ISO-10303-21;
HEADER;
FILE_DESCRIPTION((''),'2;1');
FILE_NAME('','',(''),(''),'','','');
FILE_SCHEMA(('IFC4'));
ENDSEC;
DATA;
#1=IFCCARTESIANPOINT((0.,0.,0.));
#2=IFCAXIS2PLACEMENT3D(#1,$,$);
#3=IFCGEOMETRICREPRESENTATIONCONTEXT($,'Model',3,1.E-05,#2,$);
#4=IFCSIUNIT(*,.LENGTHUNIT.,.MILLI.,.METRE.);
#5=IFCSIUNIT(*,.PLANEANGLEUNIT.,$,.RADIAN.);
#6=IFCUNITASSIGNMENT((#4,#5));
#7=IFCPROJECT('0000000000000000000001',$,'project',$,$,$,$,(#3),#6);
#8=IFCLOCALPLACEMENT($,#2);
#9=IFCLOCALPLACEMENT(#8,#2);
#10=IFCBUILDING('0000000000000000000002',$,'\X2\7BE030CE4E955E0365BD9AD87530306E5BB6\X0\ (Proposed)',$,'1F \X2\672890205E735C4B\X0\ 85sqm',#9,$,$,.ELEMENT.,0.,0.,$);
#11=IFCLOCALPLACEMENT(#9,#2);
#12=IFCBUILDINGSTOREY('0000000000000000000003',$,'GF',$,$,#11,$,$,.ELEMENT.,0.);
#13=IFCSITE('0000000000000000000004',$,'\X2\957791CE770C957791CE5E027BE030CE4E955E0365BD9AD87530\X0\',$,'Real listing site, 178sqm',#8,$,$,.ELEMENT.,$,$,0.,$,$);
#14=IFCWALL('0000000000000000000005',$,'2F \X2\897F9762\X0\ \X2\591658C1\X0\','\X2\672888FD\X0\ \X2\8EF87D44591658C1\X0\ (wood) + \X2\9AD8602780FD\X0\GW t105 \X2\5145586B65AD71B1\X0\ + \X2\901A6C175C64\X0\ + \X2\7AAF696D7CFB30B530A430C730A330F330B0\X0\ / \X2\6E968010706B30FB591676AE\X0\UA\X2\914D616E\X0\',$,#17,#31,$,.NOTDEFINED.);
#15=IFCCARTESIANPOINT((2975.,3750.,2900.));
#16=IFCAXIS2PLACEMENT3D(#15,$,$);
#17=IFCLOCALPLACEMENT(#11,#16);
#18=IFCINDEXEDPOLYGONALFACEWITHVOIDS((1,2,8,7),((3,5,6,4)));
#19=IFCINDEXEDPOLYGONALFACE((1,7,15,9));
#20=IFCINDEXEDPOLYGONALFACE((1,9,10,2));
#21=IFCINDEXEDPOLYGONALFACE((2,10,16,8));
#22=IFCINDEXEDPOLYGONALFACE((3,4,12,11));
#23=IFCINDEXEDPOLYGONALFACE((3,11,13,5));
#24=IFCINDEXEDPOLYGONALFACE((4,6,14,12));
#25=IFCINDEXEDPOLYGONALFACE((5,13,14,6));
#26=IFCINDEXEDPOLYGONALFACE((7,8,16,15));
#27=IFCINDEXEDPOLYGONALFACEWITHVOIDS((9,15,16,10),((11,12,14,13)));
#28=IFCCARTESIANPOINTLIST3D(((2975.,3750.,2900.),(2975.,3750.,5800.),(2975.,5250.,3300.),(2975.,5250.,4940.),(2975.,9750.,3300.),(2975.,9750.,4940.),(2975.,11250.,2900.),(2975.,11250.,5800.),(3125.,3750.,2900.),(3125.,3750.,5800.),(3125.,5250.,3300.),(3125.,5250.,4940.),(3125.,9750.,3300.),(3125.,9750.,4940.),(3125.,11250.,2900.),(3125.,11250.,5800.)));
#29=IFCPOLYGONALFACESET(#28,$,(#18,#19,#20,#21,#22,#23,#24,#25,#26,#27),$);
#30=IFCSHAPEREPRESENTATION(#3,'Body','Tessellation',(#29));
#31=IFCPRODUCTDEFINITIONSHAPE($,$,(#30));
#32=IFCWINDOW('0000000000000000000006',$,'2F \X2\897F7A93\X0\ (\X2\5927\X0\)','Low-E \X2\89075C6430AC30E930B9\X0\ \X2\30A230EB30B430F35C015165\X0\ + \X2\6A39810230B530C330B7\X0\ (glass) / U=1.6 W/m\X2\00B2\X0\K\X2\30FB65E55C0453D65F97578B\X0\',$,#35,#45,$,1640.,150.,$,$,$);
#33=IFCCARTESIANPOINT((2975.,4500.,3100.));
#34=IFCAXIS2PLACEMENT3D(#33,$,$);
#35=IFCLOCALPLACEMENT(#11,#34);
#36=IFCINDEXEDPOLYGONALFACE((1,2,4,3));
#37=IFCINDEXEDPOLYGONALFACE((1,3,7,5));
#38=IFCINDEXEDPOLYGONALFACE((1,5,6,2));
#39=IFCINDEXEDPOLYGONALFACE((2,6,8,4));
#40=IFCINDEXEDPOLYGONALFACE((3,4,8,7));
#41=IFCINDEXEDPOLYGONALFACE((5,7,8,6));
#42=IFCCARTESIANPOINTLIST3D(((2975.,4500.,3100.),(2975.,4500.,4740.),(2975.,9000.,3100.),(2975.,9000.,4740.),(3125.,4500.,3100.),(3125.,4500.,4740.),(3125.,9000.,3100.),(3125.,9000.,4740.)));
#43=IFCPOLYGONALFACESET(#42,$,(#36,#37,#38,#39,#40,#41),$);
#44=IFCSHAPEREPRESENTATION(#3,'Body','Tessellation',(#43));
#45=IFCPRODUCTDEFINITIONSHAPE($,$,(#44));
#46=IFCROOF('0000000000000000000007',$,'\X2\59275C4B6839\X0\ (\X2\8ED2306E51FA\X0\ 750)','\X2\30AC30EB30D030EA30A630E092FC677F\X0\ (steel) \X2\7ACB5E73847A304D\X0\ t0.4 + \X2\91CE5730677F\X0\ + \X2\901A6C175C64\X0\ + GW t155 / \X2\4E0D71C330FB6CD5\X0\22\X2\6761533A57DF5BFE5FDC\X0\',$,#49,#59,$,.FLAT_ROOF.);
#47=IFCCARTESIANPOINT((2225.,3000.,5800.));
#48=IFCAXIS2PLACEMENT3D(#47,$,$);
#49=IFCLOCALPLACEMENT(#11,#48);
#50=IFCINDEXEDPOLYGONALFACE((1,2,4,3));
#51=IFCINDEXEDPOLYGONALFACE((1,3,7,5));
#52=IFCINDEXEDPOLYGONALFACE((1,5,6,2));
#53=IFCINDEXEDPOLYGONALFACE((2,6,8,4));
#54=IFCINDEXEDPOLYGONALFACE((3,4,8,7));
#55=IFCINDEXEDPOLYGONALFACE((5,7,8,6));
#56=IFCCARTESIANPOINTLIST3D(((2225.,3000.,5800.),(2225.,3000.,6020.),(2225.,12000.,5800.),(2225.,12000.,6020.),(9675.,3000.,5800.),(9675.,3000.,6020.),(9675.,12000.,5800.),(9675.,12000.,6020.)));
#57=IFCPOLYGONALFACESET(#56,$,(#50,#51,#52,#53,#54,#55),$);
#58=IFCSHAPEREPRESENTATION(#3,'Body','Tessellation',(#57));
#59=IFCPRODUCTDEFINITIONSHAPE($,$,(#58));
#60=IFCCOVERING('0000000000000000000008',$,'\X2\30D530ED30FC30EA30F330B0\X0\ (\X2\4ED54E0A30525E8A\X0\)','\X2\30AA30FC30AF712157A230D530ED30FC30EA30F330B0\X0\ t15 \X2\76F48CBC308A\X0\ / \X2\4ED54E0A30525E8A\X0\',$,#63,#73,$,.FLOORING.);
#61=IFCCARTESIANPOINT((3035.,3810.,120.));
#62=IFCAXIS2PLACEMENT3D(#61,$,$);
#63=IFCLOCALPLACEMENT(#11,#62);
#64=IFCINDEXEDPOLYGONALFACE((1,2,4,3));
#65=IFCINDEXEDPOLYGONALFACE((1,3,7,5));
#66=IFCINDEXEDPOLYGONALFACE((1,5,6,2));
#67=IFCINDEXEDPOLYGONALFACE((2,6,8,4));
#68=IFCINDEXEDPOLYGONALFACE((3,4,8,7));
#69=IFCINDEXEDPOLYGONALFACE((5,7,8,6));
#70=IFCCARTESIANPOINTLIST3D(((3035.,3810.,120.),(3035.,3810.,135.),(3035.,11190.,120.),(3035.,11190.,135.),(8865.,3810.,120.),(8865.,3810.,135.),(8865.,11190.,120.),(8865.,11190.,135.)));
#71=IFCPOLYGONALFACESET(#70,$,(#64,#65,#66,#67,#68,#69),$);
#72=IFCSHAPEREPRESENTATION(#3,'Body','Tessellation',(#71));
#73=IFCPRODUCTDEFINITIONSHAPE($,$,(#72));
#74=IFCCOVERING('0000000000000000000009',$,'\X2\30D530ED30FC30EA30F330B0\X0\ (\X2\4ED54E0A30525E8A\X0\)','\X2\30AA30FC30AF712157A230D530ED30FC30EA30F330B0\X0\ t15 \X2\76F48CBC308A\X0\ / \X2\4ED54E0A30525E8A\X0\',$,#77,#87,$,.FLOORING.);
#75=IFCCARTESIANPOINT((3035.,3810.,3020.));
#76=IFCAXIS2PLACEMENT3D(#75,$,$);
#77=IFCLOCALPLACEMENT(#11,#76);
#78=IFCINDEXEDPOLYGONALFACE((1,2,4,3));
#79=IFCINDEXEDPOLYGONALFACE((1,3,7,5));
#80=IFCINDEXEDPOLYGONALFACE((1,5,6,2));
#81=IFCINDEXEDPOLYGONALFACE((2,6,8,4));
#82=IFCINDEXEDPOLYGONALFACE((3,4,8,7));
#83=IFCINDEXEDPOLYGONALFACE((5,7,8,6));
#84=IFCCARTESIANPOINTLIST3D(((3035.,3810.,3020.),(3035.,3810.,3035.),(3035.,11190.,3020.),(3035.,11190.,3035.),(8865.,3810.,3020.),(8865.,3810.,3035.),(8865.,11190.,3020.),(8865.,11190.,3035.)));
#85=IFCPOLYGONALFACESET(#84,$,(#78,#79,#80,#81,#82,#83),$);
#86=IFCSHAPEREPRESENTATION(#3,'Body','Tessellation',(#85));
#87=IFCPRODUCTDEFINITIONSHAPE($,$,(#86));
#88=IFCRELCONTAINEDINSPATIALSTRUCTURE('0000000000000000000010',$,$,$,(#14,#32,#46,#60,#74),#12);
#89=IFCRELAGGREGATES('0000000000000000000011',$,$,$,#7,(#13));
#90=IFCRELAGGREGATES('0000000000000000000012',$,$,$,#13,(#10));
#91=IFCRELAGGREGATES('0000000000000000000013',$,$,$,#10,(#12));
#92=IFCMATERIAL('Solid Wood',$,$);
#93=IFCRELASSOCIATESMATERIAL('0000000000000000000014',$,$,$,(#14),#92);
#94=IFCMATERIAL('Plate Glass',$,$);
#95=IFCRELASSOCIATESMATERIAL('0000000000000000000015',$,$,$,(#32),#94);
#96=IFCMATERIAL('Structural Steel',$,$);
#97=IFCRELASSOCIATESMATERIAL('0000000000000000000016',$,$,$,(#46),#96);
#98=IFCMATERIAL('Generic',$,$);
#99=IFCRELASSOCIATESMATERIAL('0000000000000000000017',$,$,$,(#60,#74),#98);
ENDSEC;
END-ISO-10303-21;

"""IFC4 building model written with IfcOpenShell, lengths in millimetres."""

from ifc_helpers import new_model, si_unit, frame, frame_2d, origin, place, context, project, spatial, rectangle, extrude, material, element, fill, save


model = new_model("IFC4")

# Units and contexts
model_context = context("Model", 3, precision=1e-05, world=origin())
ifc_project = project(units=[si_unit("LENGTHUNIT", "METRE", prefix="MILLI"), si_unit("PLANEANGLEUNIT", "RADIAN")], contexts=[model_context])

# Site, building, storey
site_placement = place(None, origin())
site = spatial("IfcSite", under=ifc_project, at=site_placement, Name="長野県長野市篠ノ井布施高田", ObjectType="Real listing site, 178sqm", CompositionType="ELEMENT", RefElevation=0.0)
building_placement = place(site_placement, origin())
building = spatial("IfcBuilding", under=site, at=building_placement, Name="篠ノ井布施高田の家 (Proposed)", ObjectType="1F 木造平屋 85sqm", CompositionType="ELEMENT", ElevationOfRefHeight=0.0, ElevationOfTerrain=0.0)
storey_placement = place(building_placement, origin())
storey = spatial("IfcBuildingStorey", under=building, at=storey_placement, Name="GF", CompositionType="ELEMENT", Elevation=0.0)

# Shared definitions
ifc_material_1 = material(Name="Solid Wood")
ifc_material_2 = material(Name="Generic")

# Shared definitions
ifc_material_3 = material(Name="Plate Glass")

# Wall, opening, window
wall_1_placement = place(storey_placement, frame((2975.0, 3750.0, 2900.0)))
wall_1 = element("IfcWall", 1, at=wall_1_placement, inside=storey, material=ifc_material_1, Name="2F 西面 外壁", Description="木製 軸組外壁 (wood) + 高性能GW t105 充填断熱 + 通気層 + 窯業系サイディング / 準耐火・外皮UA配慮", PredefinedType="NOTDEFINED", context=model_context, shape_type="SweptSolid", body=[
    extrude(rectangle(XDim=150.0, YDim=7500.0, at=frame_2d((75.0, 3750.0))), frame((2975.0, 3750.0, 2900.0)), (0.0, 0.0, 1.0), 2900.0),
])
opening_1_placement = place(storey_placement, frame((2975.0, 4500.0, 3100.0)))
opening_1 = element("IfcOpeningElement", 2, at=opening_1_placement, cuts=wall_1, PredefinedType="NOTDEFINED", context=model_context, shape_type="SweptSolid", body=[
    extrude(rectangle(XDim=150.0, YDim=4500.0, at=frame_2d((75.0, 2250.0))), frame((2975.0, 4500.0, 3100.0)), (0.0, 0.0, 1.0), 1640.0),
])
window_1_placement = place(storey_placement, frame((2975.0, 4500.0, 3100.0)))
window_1 = element("IfcWindow", 3, at=window_1_placement, inside=storey, material=ifc_material_3, Name="2F 西窓 (大)", Description="Low-E 複層ガラス アルゴン封入 + 樹脂サッシ (glass) / U=1.6 W/m²K・日射取得型", OverallHeight=1640.0, OverallWidth=150.0, context=model_context, shape_type="SweptSolid", body=[
    extrude(rectangle(XDim=150.0, YDim=4500.0, at=frame_2d((75.0, 2250.0))), frame((2975.0, 4500.0, 3100.0)), (0.0, 0.0, 1.0), 1640.0),
])
fill(opening_1, window_1)

# Roof
ifc_material_4 = material(Name="Structural Steel")
roof_placement = place(storey_placement, frame((2225.0, 3000.0, 5800.0)))
element("IfcRoof", 4, at=roof_placement, inside=storey, material=ifc_material_4, Name="大屋根 (軒の出 750)", Description="ガルバリウム鋼板 (steel) 立平葺き t0.4 + 野地板 + 通気層 + GW t155 / 不燃・法22条区域対応", PredefinedType="FLAT_ROOF", context=model_context, shape_type="SweptSolid", body=[
    extrude(rectangle(XDim=7450.0, YDim=9000.0, at=frame_2d((3725.0, 4500.0))), frame((2225.0, 3000.0, 5800.0)), (0.0, 0.0, 1.0), 220.0),
])

# Coverings
covering_1_placement = place(storey_placement, frame((3035.0, 3810.0, 120.0)))
element("IfcCovering", 5, at=covering_1_placement, inside=storey, material=ifc_material_2, Name="フローリング (仕上げ床)", Description="オーク無垢フローリング t15 直貼り / 仕上げ床", PredefinedType="FLOORING", context=model_context, shape_type="SweptSolid", body=[
    extrude(rectangle(XDim=5830.0, YDim=7380.0, at=frame_2d((2915.0, 3690.0))), frame((3035.0, 3810.0, 120.0)), (0.0, 0.0, 1.0), 15.0),
])
covering_2_placement = place(storey_placement, frame((3035.0, 3810.0, 3020.0)))
element("IfcCovering", 6, at=covering_2_placement, inside=storey, material=ifc_material_2, Name="フローリング (仕上げ床)", Description="オーク無垢フローリング t15 直貼り / 仕上げ床", PredefinedType="FLOORING", context=model_context, shape_type="SweptSolid", body=[
    extrude(rectangle(XDim=5830.0, YDim=7380.0, at=frame_2d((2915.0, 3690.0))), frame((3035.0, 3810.0, 3020.0)), (0.0, 0.0, 1.0), 15.0),
])

save(model, "model.ifc")
